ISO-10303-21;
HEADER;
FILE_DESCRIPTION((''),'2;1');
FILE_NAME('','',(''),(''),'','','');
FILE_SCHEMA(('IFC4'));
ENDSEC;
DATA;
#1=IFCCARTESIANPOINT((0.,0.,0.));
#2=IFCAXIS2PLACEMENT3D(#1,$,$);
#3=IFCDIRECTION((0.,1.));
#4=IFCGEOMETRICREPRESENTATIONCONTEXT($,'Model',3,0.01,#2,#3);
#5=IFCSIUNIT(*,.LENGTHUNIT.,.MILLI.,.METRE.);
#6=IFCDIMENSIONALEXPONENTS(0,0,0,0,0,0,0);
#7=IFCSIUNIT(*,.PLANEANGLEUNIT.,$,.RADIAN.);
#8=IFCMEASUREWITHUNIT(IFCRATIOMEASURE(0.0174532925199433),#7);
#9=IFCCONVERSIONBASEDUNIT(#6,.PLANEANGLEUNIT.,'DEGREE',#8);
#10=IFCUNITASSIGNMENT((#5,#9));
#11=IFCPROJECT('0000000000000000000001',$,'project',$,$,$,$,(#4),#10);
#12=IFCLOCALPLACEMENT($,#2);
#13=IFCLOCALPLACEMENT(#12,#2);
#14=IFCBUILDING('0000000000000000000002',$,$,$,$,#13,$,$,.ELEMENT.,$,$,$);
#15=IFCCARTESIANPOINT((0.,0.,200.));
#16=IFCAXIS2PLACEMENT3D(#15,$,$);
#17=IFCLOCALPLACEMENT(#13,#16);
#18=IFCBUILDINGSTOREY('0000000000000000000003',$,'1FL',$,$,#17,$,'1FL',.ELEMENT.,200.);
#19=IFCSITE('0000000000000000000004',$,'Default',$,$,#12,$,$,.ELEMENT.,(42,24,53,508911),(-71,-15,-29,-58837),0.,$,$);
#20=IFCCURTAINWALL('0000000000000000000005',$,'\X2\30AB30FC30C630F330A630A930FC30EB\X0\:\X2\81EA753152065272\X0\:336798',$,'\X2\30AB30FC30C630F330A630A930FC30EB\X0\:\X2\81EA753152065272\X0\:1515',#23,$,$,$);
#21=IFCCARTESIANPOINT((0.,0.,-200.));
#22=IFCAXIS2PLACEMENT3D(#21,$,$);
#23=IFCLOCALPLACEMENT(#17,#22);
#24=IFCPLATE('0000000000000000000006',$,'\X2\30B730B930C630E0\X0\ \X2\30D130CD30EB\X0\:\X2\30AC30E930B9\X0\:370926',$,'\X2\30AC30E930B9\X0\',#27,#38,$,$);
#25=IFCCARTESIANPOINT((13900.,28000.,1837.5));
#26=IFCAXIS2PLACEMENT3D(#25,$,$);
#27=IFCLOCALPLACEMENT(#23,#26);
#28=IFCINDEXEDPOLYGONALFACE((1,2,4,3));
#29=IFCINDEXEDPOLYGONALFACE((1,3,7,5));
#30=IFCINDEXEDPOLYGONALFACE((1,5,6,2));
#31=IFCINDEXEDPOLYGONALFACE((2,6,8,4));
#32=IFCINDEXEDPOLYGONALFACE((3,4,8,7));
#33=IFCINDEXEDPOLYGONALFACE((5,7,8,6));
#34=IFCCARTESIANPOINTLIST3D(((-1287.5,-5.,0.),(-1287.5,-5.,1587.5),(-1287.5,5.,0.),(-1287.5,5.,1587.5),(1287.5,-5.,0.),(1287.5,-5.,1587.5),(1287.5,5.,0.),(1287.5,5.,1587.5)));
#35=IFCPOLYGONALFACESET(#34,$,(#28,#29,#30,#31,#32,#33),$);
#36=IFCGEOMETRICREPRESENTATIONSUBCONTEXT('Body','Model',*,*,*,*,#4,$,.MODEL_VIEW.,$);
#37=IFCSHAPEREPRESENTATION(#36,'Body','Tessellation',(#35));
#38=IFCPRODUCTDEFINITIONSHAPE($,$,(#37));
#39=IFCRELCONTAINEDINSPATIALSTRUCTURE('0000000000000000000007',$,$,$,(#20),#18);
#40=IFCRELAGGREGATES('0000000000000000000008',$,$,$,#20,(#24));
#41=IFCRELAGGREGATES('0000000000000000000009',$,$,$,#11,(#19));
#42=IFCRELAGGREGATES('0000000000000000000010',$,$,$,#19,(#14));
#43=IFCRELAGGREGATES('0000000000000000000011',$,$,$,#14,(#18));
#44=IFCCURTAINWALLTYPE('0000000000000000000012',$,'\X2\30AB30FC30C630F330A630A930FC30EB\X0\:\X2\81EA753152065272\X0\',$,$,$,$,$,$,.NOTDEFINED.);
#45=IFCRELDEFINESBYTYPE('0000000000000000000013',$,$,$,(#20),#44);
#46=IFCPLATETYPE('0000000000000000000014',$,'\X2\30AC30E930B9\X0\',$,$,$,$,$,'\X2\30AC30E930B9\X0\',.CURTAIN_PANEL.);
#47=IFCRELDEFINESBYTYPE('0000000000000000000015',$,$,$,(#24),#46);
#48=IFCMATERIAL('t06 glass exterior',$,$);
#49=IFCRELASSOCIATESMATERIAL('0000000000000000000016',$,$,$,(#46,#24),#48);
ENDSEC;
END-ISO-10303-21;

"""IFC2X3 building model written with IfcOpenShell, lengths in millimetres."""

from ifc_helpers import new_model, entity, si_unit, converted_unit, direction, frame, origin, origin_2d_with_axis, place, context, subcontext, project, spatial, rectangle, extrude, source, transform, mapped, material, type_object, type_shapes, element, aggregate, save


model = new_model("IFC2X3")

# Units and contexts
model_context = context("Model", 3, precision=0.01, world=origin(), true_north=direction((0.0, 1.0)))
body_context = subcontext(model_context, "Body", "Model", "MODEL_VIEW")
ifc_project = project(units=[si_unit("LENGTHUNIT", "METRE", prefix="MILLI"), converted_unit("PLANEANGLEUNIT", "DEGREE", entity("IfcRatioMeasure", 0.0174532925199433), si_unit("PLANEANGLEUNIT", "RADIAN"), dimensions=[0, 0, 0, 0, 0, 0, 0])], contexts=[model_context])

# Site, building, storey
site_placement = place(None, origin())
site = spatial("IfcSite", under=ifc_project, at=site_placement, Name="Default", CompositionType="ELEMENT", RefLatitude=(42, 24, 53, 508911), RefLongitude=(-71, -15, -29, -58837), RefElevation=0.0)
building_placement = place(site_placement, origin())
building = spatial("IfcBuilding", under=site, at=building_placement, CompositionType="ELEMENT")
storey_placement = place(building_placement, frame((0.0, 0.0, 200.0)))
storey = spatial("IfcBuildingStorey", under=building, at=storey_placement, Name="1FL", LongName="1FL", CompositionType="ELEMENT", Elevation=200.0)

# Curtain wall, plate
curtain_wall_type = type_object("IfcCurtainWallType", Name="カーテンウォール:自由分割", PredefinedType="NOTDEFINED")
ifc_material_1 = material(Name="t06 glass exterior")
curtain_wall_1_placement = place(storey_placement, frame((0.0, 0.0, -200.0)))
curtain_wall_1 = element("IfcCurtainWall", 1, at=curtain_wall_1_placement, inside=storey, type_object=curtain_wall_type, Name="カーテンウォール:自由分割:336798", ObjectType="カーテンウォール:自由分割:1515")
plate_type_1 = type_object("IfcPlateType", Name="ガラス", ElementType="ガラス", PredefinedType="CURTAIN_PANEL", material=ifc_material_1)
shared_shape_1 = source(origin(), body_context, "Body", "SweptSolid", [
    extrude(rectangle(XDim=10.0, YDim=2575.0, at=origin_2d_with_axis()), frame((0.0, 0.0, 0.0), z_axis=(0.0, 0.0, 1.0), x_axis=(0.0, 1.0, 0.0)), (0.0, 0.0, 1.0), 1587.5),
])
type_shapes(plate_type_1, [shared_shape_1])
plate_1_placement = place(curtain_wall_1_placement, frame((13900.0, 28000.0, 1837.5)))
plate_1 = element("IfcPlate", 2, at=plate_1_placement, type_object=plate_type_1, material=ifc_material_1, Name="システム パネル:ガラス:370926", ObjectType="ガラス", context=body_context, shape_type="MappedRepresentation", body=[
    mapped(shared_shape_1, transform((0.0, 0.0, 0.0), scale=1.0)),
])
aggregate(curtain_wall_1, [plate_1])

save(model, "model.ifc")
